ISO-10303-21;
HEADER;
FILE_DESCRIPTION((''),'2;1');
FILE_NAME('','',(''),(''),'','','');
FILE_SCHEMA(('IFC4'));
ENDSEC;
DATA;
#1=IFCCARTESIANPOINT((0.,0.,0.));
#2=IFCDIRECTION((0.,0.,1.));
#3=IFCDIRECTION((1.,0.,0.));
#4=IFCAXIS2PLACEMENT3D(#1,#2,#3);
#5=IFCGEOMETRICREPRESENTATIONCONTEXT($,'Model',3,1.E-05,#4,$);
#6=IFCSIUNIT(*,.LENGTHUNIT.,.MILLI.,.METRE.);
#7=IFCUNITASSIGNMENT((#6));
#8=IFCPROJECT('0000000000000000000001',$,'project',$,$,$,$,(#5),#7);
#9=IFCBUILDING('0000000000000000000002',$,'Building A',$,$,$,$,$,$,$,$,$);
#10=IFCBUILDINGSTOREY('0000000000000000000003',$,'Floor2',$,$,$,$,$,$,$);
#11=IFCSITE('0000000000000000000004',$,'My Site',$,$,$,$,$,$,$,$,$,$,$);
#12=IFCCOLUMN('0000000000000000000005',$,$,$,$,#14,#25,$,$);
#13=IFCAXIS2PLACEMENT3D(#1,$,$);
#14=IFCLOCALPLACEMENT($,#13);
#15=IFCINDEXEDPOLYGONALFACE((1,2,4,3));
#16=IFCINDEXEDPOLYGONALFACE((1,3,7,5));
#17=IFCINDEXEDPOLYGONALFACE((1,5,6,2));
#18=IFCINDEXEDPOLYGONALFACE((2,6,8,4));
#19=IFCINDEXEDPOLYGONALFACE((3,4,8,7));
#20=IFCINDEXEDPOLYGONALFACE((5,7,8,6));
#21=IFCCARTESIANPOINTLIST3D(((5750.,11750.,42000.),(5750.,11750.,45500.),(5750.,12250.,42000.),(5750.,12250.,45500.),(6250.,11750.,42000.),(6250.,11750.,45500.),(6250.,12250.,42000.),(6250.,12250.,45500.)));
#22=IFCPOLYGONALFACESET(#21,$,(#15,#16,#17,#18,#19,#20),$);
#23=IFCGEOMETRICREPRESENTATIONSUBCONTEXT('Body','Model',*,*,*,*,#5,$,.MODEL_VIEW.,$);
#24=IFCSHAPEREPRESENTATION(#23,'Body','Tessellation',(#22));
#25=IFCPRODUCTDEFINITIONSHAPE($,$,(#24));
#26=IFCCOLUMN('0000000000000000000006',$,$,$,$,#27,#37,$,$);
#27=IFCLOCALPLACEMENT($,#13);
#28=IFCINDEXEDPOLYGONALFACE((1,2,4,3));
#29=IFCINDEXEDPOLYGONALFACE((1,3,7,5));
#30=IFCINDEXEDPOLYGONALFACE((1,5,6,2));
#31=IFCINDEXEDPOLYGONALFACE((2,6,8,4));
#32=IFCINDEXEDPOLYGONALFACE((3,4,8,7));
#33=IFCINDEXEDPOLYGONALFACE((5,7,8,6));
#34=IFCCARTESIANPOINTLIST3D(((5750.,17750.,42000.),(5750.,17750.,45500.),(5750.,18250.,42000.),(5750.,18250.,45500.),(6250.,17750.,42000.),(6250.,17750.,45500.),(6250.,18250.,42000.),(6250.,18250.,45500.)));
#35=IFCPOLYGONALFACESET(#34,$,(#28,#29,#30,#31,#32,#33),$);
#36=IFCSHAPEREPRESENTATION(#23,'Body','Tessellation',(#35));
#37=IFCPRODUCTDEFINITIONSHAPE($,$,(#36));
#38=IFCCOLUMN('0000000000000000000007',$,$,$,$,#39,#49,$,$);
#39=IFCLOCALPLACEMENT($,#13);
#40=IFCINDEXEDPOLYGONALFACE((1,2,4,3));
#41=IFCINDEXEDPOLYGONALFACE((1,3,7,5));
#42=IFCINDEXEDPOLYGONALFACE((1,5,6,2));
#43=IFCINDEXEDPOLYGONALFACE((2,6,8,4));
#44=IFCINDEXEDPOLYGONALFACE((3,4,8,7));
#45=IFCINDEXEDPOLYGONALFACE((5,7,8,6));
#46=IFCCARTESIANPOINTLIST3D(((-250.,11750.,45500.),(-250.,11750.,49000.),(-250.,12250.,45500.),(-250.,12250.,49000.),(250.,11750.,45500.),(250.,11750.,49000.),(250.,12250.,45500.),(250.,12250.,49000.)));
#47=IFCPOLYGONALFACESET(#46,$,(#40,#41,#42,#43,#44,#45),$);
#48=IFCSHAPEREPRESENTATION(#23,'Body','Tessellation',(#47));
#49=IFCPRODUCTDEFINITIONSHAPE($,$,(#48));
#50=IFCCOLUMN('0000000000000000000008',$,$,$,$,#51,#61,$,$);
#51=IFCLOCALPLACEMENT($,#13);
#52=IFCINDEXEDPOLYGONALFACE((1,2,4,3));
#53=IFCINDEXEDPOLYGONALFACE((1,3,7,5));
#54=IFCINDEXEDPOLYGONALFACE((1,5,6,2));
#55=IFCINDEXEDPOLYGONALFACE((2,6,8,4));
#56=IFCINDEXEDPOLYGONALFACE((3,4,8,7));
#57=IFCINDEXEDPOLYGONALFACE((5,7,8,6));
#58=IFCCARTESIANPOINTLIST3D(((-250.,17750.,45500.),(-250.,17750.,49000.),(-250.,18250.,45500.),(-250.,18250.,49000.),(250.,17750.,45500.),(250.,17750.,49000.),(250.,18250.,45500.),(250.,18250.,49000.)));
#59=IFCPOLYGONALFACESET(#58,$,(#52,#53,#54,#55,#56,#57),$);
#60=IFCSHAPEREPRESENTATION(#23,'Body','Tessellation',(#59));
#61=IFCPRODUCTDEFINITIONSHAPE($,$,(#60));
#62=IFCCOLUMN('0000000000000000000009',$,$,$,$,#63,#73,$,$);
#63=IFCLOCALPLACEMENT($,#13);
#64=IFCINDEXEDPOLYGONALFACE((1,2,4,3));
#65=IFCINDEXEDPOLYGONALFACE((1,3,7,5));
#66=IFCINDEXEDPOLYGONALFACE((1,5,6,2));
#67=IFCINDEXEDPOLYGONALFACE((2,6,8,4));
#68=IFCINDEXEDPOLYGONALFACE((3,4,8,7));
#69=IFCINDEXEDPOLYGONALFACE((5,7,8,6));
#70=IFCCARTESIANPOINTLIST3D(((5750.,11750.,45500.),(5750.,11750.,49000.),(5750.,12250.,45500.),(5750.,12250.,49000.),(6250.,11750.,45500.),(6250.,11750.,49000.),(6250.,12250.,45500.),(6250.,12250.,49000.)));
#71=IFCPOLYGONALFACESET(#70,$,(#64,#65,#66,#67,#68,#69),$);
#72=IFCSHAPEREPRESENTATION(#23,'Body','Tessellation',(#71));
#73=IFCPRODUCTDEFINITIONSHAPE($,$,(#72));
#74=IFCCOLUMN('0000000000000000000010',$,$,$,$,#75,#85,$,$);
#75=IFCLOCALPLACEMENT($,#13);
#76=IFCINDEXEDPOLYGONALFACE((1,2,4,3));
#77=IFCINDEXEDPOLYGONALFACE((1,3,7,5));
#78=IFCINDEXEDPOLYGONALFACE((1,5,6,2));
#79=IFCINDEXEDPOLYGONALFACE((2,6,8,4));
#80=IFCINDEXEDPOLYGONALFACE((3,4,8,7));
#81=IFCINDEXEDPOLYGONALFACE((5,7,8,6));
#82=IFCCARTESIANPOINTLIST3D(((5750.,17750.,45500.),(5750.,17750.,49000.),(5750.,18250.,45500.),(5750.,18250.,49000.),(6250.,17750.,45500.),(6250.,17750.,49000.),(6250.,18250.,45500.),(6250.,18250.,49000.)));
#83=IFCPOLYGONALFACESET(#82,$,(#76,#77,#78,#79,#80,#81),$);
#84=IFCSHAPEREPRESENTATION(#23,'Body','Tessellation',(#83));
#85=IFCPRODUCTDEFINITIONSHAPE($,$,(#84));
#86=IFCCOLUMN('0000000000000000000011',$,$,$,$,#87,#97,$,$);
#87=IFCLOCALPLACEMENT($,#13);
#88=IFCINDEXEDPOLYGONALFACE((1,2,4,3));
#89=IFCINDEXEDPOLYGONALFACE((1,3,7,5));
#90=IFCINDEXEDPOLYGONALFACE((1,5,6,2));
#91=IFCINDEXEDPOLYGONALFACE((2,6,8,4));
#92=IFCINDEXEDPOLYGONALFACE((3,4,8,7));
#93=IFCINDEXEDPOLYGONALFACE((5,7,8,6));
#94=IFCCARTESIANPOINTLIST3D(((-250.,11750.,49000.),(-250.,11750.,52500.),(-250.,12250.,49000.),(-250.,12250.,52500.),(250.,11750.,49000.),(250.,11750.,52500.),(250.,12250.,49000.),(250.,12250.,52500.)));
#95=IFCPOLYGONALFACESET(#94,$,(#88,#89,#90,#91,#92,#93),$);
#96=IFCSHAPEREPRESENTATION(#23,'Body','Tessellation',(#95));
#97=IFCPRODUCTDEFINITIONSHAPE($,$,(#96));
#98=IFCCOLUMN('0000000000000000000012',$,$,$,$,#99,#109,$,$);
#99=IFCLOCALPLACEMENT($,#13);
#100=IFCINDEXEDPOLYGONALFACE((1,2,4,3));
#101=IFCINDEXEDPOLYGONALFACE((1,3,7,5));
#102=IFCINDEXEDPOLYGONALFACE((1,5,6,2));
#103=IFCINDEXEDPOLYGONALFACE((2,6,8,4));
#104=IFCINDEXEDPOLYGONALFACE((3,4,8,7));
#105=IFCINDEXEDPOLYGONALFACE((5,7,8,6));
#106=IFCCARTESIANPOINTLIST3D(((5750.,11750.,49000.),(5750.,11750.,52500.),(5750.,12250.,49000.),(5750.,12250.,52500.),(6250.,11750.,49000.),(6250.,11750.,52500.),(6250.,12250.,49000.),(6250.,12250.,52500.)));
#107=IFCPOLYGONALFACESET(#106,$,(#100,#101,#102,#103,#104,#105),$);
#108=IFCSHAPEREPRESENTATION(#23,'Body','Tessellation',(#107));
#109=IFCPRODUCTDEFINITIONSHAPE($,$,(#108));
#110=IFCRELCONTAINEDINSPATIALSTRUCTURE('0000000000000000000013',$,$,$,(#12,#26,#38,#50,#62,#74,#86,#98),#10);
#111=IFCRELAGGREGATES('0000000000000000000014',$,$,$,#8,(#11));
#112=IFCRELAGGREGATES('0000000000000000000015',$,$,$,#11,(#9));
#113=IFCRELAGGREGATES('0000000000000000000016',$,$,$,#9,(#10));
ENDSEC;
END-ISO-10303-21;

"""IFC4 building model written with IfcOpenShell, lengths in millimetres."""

from ifc_helpers import new_model, si_unit, frame, origin_with_axes, place, context, subcontext, project, spatial, line, indexed_curve, outline, extrude, element, save


model = new_model("IFC4")

# Units and contexts
model_context = context("Model", 3, precision=1e-05, world=origin_with_axes())
body_context = subcontext(model_context, "Body", "Model", "MODEL_VIEW")
ifc_project = project(units=[si_unit("LENGTHUNIT", "METRE", prefix="MILLI")], contexts=[model_context])

# Site, building, storey
site = spatial("IfcSite", under=ifc_project, Name="My Site")
building = spatial("IfcBuilding", under=site, Name="Building A")
storey = spatial("IfcBuildingStorey", under=building, Name="Floor2")

# Columns
for number, where, z_axis, x_axis in (
    (1, (6000.0, 12000.0, 42000.0), (0.0, 0.0, 1.0), (1.0, 0.0, 0.0)),
    (2, (6000.0, 18000.0, 42000.0), (0.0, 0.0, 1.0), (1.0, 0.0, 0.0)),
    (3, (0.0, 12000.0, 45500.0), (0.0, 0.0, 1.0), (1.0, 0.0, 0.0)),
    (4, (0.0, 18000.0, 45500.0), (0.0, 0.0, 1.0), (1.0, 0.0, 0.0)),
    (5, (6000.0, 12000.0, 45500.0), (0.0, 0.0, 1.0), (1.0, 0.0, 0.0)),
    (6, (6000.0, 18000.0, 45500.0), (0.0, 0.0, 1.0), (1.0, 0.0, 0.0)),
    (7, (0.0, 12000.0, 49000.0), (0.0, 0.0, 1.0), (1.0, 0.0, 0.0)),
    (8, (6000.0, 12000.0, 49000.0), (0.0, 0.0, 1.0), (1.0, 0.0, 0.0)),
):
    element("IfcColumn", number, at=place(None, frame(where, z_axis=z_axis, x_axis=x_axis)), inside=storey, context=body_context, shape_type="SweptSolid", body=[
        extrude(outline(indexed_curve([(-250.0, -250.0), (250.0, -250.0), (250.0, 250.0), (-250.0, 250.0)], segments=[line(1, 2, 3, 4, 1)])), origin_with_axes(), (0.0, 0.0, 1.0), 3500.0),
    ])

save(model, "model.ifc")
